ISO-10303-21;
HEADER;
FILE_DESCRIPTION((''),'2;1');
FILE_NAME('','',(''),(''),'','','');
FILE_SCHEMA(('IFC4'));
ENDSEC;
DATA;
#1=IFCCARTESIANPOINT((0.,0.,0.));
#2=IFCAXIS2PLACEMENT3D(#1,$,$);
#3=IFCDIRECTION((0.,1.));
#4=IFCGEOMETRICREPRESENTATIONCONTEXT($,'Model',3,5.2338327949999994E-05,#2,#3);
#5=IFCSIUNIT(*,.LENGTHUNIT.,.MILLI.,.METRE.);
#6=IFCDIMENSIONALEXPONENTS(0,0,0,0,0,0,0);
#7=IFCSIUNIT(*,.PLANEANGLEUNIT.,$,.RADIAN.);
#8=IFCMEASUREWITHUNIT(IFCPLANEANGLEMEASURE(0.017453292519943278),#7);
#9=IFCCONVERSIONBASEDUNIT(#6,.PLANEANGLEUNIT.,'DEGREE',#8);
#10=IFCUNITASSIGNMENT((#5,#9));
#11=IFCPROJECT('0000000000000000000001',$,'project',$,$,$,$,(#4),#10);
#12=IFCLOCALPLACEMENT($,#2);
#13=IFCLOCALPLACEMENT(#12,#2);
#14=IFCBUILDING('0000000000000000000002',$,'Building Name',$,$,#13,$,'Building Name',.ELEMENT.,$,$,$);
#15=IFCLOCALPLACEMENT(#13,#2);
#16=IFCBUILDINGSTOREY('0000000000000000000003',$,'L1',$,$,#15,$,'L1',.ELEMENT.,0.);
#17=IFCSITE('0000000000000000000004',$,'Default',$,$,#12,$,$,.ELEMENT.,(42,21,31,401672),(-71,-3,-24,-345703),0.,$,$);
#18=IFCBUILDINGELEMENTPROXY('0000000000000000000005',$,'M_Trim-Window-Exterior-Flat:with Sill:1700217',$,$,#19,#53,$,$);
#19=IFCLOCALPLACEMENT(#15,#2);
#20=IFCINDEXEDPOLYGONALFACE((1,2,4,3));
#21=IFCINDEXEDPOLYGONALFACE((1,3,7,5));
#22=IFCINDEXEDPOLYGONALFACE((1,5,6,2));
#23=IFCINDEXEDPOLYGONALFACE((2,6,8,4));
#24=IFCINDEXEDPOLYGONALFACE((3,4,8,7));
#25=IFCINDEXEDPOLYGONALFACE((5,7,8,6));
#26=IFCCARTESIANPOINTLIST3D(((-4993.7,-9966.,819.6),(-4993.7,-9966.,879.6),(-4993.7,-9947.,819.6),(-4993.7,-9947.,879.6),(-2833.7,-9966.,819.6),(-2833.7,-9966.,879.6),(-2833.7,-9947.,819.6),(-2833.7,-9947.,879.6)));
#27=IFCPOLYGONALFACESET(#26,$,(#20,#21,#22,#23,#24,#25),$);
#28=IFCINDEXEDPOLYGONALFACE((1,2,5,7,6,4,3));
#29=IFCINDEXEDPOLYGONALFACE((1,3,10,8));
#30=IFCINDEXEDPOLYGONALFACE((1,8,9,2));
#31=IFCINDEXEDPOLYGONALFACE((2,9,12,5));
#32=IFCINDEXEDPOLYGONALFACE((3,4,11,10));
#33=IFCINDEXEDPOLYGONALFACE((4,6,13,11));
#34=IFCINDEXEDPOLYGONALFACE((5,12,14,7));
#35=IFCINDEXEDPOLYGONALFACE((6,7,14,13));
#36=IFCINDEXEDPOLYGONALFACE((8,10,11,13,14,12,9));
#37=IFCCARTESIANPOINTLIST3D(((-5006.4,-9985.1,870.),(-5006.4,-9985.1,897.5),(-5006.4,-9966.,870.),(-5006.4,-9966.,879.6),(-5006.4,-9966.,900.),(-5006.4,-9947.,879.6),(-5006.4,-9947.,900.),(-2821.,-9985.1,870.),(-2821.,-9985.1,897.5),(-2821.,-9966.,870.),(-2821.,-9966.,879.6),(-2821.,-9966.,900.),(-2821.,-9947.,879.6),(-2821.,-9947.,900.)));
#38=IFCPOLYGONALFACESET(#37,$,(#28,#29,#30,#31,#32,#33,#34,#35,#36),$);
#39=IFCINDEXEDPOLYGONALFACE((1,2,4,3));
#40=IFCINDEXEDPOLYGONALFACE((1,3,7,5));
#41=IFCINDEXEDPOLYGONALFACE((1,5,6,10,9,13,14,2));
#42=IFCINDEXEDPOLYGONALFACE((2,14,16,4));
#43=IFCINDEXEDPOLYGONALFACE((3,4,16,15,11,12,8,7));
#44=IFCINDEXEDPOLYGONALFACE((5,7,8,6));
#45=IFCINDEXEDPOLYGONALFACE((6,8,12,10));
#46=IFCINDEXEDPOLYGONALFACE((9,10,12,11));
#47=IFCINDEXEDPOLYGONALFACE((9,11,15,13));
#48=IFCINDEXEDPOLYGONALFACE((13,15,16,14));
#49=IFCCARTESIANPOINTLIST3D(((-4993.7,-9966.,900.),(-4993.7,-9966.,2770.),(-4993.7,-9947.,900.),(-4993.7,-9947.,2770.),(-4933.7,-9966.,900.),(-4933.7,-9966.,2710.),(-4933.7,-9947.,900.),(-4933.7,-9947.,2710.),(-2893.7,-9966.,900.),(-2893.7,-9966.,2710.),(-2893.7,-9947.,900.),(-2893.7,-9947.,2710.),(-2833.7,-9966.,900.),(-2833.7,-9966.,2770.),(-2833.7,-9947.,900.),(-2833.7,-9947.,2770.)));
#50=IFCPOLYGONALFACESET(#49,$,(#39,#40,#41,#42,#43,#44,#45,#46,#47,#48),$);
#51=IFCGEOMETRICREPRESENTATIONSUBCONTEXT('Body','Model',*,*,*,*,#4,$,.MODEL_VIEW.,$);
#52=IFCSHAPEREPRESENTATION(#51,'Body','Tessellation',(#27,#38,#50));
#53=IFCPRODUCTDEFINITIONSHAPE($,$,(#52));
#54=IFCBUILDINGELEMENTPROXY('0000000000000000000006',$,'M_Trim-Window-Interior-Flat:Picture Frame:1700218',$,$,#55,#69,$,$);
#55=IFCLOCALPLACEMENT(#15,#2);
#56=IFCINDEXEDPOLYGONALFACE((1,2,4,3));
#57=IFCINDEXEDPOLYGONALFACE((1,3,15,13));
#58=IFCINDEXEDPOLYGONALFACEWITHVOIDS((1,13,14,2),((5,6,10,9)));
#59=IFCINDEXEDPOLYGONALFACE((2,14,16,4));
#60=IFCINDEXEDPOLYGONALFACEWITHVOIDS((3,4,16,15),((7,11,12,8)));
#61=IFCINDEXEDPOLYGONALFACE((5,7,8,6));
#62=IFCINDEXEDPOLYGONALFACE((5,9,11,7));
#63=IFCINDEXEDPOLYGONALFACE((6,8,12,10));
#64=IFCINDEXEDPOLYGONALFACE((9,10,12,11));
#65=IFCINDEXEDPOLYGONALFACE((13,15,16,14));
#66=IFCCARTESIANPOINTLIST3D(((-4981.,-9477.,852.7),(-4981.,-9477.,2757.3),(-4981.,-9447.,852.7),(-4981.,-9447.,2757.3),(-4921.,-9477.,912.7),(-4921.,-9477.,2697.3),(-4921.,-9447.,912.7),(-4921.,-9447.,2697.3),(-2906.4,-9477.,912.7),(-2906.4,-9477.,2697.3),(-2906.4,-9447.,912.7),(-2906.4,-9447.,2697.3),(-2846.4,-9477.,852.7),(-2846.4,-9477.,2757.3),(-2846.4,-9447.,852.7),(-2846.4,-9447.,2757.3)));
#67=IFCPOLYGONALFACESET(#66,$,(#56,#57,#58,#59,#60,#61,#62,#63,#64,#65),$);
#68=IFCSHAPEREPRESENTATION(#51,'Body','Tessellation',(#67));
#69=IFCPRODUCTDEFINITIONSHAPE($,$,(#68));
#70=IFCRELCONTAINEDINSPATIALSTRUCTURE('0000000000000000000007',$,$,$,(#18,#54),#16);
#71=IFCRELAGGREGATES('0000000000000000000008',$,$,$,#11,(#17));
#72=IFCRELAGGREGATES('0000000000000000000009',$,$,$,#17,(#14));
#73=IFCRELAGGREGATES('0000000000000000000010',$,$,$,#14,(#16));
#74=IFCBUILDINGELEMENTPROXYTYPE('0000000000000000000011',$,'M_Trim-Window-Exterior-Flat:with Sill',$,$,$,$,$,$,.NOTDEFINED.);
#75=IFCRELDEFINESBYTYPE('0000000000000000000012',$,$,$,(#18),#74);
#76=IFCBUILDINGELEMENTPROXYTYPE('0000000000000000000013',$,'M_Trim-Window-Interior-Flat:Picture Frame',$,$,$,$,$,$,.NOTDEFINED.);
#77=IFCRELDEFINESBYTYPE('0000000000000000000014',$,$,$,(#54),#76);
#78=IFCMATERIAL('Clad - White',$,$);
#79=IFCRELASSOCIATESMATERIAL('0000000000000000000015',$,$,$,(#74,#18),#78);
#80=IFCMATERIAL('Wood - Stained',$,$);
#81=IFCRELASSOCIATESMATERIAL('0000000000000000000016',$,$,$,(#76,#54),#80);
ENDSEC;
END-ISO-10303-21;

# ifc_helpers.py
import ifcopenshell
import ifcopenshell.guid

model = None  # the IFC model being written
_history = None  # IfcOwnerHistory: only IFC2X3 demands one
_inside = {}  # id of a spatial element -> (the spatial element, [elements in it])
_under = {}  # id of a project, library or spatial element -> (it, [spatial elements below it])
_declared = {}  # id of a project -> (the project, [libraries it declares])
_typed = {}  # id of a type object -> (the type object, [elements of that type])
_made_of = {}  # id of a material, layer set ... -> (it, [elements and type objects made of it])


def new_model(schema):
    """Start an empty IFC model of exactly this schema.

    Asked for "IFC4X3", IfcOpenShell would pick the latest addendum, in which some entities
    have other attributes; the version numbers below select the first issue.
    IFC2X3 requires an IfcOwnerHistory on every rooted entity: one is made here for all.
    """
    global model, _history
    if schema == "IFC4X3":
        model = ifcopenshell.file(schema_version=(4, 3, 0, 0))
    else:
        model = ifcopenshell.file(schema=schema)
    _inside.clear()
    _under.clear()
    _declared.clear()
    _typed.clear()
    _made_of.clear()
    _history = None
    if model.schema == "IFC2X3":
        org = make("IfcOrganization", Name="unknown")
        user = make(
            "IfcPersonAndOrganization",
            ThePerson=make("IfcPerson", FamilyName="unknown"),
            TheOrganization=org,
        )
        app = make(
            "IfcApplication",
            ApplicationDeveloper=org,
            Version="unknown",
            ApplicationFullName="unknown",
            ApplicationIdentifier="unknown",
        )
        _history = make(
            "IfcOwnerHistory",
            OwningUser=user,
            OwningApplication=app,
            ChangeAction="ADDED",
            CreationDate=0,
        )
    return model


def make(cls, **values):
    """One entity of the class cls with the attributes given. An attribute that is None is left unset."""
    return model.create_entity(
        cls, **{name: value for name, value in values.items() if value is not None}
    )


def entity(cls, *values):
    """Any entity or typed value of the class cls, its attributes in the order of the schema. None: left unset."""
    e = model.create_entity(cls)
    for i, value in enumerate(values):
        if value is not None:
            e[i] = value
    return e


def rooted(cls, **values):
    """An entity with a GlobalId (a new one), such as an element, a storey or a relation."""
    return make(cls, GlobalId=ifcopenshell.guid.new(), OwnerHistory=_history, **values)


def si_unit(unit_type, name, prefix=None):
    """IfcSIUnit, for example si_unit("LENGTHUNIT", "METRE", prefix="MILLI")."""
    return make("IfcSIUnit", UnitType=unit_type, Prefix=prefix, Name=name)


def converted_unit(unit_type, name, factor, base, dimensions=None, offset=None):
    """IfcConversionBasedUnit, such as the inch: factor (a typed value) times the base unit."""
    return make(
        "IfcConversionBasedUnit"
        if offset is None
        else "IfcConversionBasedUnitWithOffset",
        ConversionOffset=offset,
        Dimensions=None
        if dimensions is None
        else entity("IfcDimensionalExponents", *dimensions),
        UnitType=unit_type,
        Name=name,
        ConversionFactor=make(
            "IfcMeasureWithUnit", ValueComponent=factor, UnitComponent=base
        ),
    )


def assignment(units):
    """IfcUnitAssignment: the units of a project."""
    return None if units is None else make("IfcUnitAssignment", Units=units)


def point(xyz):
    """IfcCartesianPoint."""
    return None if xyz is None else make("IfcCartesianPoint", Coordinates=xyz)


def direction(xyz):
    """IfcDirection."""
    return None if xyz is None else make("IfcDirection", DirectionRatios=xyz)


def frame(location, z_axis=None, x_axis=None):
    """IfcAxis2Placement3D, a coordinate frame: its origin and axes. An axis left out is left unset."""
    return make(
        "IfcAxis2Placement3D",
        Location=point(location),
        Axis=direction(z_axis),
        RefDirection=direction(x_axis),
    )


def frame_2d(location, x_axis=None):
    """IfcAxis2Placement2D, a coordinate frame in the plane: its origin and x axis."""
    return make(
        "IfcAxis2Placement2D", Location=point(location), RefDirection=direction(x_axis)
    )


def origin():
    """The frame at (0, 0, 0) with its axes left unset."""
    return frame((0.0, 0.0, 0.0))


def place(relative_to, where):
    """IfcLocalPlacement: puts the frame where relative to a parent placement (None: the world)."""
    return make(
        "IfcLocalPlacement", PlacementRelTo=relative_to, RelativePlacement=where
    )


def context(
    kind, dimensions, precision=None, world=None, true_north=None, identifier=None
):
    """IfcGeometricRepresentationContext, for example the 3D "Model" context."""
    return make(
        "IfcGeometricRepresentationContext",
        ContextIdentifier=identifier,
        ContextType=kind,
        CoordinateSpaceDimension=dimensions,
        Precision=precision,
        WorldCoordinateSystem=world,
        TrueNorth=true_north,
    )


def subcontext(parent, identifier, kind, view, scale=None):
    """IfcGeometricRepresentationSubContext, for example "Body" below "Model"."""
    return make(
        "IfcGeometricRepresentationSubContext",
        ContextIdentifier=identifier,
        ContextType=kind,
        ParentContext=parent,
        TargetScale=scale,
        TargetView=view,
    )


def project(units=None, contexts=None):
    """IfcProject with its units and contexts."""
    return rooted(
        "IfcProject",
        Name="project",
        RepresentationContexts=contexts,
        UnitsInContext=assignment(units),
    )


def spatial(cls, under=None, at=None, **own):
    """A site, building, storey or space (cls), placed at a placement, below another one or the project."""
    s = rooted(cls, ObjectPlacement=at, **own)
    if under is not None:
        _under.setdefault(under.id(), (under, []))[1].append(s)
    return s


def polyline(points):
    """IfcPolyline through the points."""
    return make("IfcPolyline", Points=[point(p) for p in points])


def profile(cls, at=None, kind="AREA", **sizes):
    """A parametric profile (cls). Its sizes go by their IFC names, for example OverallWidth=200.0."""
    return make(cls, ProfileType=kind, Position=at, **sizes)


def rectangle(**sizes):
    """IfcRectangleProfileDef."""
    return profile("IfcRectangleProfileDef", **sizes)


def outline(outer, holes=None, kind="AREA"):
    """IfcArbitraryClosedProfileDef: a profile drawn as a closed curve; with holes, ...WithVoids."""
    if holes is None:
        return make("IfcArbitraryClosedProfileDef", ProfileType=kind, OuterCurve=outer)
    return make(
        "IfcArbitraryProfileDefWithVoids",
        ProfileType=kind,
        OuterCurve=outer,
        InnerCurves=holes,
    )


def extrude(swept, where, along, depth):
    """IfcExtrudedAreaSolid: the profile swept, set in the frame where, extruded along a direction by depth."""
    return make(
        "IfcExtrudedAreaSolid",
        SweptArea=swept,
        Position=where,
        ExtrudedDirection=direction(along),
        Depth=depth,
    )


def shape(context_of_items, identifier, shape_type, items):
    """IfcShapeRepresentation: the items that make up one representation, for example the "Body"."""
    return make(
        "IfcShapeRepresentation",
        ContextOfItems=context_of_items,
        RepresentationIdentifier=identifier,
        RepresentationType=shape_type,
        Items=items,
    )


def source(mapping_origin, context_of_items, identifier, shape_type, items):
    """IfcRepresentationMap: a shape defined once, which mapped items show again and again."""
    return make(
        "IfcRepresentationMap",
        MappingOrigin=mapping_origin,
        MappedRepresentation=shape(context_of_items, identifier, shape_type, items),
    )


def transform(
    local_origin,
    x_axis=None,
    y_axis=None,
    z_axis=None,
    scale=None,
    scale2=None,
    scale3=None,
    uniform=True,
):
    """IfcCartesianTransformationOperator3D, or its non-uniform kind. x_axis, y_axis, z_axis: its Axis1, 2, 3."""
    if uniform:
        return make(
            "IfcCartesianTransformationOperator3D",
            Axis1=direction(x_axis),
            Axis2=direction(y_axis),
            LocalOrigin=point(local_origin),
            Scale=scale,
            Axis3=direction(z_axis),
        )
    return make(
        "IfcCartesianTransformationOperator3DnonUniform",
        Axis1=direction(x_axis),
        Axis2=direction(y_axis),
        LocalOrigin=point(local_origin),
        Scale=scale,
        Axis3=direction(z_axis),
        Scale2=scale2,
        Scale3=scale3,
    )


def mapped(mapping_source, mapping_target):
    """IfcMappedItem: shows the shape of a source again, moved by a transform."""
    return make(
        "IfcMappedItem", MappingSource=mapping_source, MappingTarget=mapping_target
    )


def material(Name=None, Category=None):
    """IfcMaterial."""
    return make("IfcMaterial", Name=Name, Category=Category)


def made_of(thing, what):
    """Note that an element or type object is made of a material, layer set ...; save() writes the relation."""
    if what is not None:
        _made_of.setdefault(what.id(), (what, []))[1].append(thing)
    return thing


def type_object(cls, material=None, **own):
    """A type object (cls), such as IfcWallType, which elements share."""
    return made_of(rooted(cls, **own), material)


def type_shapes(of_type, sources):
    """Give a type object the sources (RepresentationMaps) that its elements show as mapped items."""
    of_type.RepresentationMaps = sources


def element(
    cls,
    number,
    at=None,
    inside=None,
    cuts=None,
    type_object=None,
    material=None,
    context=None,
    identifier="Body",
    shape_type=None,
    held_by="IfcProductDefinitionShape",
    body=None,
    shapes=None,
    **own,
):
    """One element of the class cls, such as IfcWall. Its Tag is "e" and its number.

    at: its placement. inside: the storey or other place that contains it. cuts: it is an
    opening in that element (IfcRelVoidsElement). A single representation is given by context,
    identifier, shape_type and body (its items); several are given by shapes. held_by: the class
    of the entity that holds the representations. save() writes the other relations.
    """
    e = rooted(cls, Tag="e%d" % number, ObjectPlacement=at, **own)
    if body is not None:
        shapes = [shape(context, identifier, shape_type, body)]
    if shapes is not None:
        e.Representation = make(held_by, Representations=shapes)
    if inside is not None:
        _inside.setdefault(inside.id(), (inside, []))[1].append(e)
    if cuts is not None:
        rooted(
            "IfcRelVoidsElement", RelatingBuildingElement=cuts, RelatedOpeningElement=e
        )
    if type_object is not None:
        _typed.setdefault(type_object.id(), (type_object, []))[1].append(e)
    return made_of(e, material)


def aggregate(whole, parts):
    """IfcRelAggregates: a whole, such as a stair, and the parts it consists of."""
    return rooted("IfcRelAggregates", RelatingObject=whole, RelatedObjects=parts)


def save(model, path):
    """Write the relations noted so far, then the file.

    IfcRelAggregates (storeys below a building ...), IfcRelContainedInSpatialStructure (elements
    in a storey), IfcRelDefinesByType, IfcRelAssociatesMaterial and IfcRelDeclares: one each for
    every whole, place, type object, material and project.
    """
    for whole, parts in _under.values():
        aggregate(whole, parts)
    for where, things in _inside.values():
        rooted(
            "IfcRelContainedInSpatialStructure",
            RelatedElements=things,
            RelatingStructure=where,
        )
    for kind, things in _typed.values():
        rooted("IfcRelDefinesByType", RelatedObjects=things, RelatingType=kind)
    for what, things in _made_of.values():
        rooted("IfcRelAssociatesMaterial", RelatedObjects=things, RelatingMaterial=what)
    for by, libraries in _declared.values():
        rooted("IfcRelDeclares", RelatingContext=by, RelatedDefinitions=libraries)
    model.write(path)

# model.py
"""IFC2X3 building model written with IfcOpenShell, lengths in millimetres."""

from ifc_helpers import new_model, entity, si_unit, converted_unit, direction, frame, frame_2d, origin, place, context, subcontext, project, spatial, polyline, rectangle, outline, extrude, source, transform, mapped, material, type_object, type_shapes, element, save


model = new_model("IFC2X3")

# Units and contexts
model_context = context("Model", 3, precision=5.2338327949999994e-05, world=origin(), true_north=direction((0.0, 1.0)))
body_context = subcontext(model_context, "Body", "Model", "MODEL_VIEW")
ifc_project = project(units=[si_unit("LENGTHUNIT", "METRE", prefix="MILLI"), converted_unit("PLANEANGLEUNIT", "DEGREE", entity("IfcPlaneAngleMeasure", 0.017453292519943278), si_unit("PLANEANGLEUNIT", "RADIAN"), dimensions=[0, 0, 0, 0, 0, 0, 0])], contexts=[model_context])

# Site, building, storey
site_placement = place(None, origin())
site = spatial("IfcSite", under=ifc_project, at=site_placement, Name="Default", CompositionType="ELEMENT", RefLatitude=(42, 21, 31, 401672), RefLongitude=(-71, -3, -24, -345703), RefElevation=0.0)
building_placement = place(site_placement, origin())
building = spatial("IfcBuilding", under=site, at=building_placement, Name="Building Name", LongName="Building Name", CompositionType="ELEMENT")
storey_placement = place(building_placement, origin())
storey = spatial("IfcBuildingStorey", under=building, at=storey_placement, Name="L1", LongName="L1", CompositionType="ELEMENT", Elevation=0.0)

# Building element proxies
ifc_material_1 = material(Name="Clad - White")
ifc_material_2 = material(Name="Wood - Stained")
building_element_proxy_type_1 = type_object("IfcBuildingElementProxyType", Name="M_Trim-Window-Exterior-Flat:with Sill", PredefinedType="NOTDEFINED", material=ifc_material_1)
shared_shape_1 = source(origin(), body_context, "Body", "SweptSolid", [
    extrude(rectangle(XDim=2160.0, YDim=60.0, at=frame_2d((0.0, 0.0), x_axis=(1.0, 0.0))), frame((0.0, -1860.4, 0.0), z_axis=(0.0, 0.0, 1.0), x_axis=(-1.0, 0.0, 0.0)), (0.0, 0.0, 1.0), 19.0),
    extrude(outline(polyline([(-19.0, -15.2), (0.0, -15.2), (0.0, -5.7), (19.0, -5.7), (19.0, 14.8), (0.0, 14.8), (-19.0, 12.3), (-19.0, -15.2)])), frame((-1092.7, -1824.8, 19.0), z_axis=(1.0, 0.0, 0.0), x_axis=(0.0, 0.0, -1.0)), (0.0, 0.0, 1.0), 2185.4),
    extrude(outline(polyline([(-950.0, -1080.0), (920.0, -1080.0), (920.0, -1020.0), (-890.0, -1020.0), (-890.0, 1020.0), (920.0, 1020.0), (920.0, 1080.0), (-950.0, 1080.0), (-950.0, -1080.0)])), frame((0.0, -890.0, 0.0), z_axis=(0.0, 0.0, 1.0), x_axis=(0.0, -1.0, 0.0)), (0.0, 0.0, 1.0), 19.0),
])
type_shapes(building_element_proxy_type_1, [shared_shape_1])
proxy_1_placement = place(storey_placement, frame((-3913.7, -9947.0, 2710.0), z_axis=(0.0, -1.0, 0.0), x_axis=(1.0, 0.0, 0.0)))
element("IfcBuildingElementProxy", 1, at=proxy_1_placement, inside=storey, type_object=building_element_proxy_type_1, material=ifc_material_1, Name="M_Trim-Window-Exterior-Flat:with Sill:1700217", context=body_context, shape_type="MappedRepresentation", body=[
    mapped(shared_shape_1, transform((0.0, 0.0, 0.0), scale=1.0)),
])
building_element_proxy_type_2 = type_object("IfcBuildingElementProxyType", Name="M_Trim-Window-Interior-Flat:Picture Frame", PredefinedType="NOTDEFINED", material=ifc_material_2)
shared_shape_2 = source(origin(), body_context, "Body", "SweptSolid", [
    extrude(outline(polyline([(-1067.3, -952.3), (1067.3, -952.3), (1067.3, 952.3), (-1067.3, 952.3), (-1067.3, -952.3)]), holes=[polyline([(-1007.3, -892.3), (-1007.3, 892.3), (1007.3, 892.3), (1007.3, -892.3), (-1007.3, -892.3)])]), frame((0.0, -905.0, 0.0), z_axis=(0.0, 0.0, 1.0), x_axis=(-1.0, 0.0, 0.0)), (0.0, 0.0, 1.0), 30.0),
])
type_shapes(building_element_proxy_type_2, [shared_shape_2])
proxy_2_placement = place(storey_placement, frame((-3913.7, -9477.0, 2710.0), z_axis=(0.0, 1.0, 0.0), x_axis=(-1.0, 0.0, 0.0)))
element("IfcBuildingElementProxy", 2, at=proxy_2_placement, inside=storey, type_object=building_element_proxy_type_2, material=ifc_material_2, Name="M_Trim-Window-Interior-Flat:Picture Frame:1700218", context=body_context, shape_type="MappedRepresentation", body=[
    mapped(shared_shape_2, transform((0.0, 0.0, 0.0), scale=1.0)),
])

save(model, "model.ifc")
